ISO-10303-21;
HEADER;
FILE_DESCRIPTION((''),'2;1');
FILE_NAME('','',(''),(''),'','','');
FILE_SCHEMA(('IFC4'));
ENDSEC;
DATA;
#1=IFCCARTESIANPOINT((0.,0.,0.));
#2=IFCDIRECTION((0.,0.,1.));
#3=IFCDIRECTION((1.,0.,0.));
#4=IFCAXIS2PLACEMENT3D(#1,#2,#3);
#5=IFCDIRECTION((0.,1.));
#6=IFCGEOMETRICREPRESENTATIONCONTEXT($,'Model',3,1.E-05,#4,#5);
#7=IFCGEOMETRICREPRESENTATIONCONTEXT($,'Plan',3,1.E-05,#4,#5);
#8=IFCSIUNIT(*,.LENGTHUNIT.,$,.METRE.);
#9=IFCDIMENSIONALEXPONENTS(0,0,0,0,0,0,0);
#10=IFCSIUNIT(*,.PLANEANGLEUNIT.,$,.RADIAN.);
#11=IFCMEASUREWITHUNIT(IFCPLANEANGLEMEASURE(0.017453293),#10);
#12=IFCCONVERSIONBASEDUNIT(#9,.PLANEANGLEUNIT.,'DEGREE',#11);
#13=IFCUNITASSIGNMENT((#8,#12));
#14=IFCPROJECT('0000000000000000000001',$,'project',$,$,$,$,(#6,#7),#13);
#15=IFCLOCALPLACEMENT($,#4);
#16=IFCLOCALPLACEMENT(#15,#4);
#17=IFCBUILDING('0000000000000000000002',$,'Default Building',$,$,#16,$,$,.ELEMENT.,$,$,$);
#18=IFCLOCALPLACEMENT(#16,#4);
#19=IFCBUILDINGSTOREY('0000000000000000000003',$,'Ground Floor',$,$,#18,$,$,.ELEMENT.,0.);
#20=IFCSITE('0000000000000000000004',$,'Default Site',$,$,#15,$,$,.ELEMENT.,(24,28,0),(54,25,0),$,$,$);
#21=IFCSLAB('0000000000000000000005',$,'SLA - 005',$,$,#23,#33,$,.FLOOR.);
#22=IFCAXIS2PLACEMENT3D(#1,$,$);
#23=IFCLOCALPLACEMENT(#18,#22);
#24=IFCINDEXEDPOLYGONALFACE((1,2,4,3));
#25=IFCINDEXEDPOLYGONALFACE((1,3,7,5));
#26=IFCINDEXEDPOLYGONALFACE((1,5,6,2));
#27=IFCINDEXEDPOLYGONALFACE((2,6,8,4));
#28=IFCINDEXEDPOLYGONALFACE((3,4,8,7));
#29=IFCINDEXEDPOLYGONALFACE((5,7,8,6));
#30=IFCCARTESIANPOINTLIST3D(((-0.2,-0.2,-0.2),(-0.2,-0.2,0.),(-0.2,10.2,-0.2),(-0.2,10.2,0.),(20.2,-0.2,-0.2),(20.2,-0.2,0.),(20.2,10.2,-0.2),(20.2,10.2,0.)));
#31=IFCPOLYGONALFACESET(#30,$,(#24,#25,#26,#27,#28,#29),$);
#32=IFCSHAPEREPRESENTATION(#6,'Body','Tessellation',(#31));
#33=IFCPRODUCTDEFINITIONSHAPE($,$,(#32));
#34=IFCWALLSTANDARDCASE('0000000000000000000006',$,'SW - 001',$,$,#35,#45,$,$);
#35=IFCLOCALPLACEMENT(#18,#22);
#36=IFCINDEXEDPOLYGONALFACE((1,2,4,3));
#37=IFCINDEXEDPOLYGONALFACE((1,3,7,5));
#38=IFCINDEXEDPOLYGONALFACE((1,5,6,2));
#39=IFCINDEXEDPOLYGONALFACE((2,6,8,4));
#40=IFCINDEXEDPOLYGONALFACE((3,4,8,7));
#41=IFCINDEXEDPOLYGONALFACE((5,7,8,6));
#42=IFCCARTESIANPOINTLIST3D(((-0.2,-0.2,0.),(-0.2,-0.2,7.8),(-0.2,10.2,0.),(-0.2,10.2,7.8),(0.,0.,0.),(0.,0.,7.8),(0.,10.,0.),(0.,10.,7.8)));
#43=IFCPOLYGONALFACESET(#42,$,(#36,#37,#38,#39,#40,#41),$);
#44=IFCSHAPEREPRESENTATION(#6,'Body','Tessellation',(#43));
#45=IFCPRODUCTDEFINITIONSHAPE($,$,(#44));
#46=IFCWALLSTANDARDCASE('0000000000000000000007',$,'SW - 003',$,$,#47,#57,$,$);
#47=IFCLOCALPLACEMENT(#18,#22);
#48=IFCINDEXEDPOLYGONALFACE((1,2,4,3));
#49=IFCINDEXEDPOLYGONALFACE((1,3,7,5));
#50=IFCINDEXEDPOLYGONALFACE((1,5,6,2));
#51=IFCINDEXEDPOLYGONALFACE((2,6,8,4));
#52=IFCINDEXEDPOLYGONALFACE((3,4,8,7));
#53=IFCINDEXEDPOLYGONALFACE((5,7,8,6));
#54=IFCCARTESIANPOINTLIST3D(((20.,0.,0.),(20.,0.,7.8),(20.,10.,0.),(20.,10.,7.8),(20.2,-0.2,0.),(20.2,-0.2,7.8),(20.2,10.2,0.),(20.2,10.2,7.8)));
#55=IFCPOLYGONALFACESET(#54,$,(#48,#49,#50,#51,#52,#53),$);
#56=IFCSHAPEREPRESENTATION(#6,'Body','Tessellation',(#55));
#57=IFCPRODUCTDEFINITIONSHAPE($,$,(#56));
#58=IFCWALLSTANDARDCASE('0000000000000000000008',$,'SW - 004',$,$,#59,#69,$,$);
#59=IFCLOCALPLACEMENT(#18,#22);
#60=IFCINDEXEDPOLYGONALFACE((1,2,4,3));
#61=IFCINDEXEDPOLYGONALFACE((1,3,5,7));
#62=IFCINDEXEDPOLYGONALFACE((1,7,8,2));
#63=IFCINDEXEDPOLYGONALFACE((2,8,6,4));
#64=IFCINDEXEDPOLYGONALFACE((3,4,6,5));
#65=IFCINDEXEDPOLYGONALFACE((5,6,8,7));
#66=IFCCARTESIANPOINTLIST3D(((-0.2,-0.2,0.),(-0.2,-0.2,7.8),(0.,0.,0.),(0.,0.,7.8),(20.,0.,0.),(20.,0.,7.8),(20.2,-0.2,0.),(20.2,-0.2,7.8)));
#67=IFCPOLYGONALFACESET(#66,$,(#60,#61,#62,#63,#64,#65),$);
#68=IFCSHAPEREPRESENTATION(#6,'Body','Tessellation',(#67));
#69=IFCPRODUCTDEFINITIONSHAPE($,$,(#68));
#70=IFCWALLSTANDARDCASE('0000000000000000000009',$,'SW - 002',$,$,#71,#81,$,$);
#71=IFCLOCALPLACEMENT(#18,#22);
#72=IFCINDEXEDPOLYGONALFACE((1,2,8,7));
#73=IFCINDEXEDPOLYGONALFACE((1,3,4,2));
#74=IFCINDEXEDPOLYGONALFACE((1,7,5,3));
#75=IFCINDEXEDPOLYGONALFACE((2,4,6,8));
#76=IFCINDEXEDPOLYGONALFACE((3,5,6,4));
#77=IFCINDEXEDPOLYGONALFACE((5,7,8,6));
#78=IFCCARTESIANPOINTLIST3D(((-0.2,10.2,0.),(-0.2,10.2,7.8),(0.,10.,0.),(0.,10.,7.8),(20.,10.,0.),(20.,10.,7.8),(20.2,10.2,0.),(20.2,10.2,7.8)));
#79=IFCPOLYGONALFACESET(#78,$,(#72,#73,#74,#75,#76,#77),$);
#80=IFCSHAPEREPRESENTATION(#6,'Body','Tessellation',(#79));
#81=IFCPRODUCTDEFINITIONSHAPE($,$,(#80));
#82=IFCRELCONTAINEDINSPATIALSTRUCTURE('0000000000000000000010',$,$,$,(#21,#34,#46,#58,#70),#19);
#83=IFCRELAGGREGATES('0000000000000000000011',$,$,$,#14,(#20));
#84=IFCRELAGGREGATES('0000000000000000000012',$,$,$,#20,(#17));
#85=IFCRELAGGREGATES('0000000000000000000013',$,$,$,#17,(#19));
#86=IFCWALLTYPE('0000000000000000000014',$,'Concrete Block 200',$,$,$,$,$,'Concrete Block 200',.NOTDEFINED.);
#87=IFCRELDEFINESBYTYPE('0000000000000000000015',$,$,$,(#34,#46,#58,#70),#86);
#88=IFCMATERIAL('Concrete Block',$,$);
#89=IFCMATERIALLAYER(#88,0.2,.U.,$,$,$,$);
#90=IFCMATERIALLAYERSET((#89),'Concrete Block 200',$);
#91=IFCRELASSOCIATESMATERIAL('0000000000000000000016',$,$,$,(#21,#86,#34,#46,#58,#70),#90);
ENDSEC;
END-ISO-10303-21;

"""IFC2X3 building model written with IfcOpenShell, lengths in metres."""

from ifc_helpers import new_model, entity, si_unit, converted_unit, direction, frame, origin_with_axes, place, context, project, spatial, polyline, outline, extrude, material, layer, layer_set, layer_usage, type_object, element, save


model = new_model("IFC2X3")

# Units and contexts
model_context = context("Model", 3, precision=1e-05, world=origin_with_axes(), true_north=direction((0.0, 1.0)))
plan_context = context("Plan", 3, precision=1e-05, world=origin_with_axes(), true_north=direction((0.0, 1.0)))
ifc_project = project(units=[si_unit("LENGTHUNIT", "METRE"), converted_unit("PLANEANGLEUNIT", "DEGREE", entity("IfcPlaneAngleMeasure", 0.017453293), si_unit("PLANEANGLEUNIT", "RADIAN"), dimensions=[0, 0, 0, 0, 0, 0, 0])], contexts=[model_context, plan_context])

# Site, building, storey
site_placement = place(None, origin_with_axes())
site = spatial("IfcSite", under=ifc_project, at=site_placement, Name="Default Site", CompositionType="ELEMENT", RefLatitude=(24, 28, 0), RefLongitude=(54, 25, 0))
building_placement = place(site_placement, origin_with_axes())
building = spatial("IfcBuilding", under=site, at=building_placement, Name="Default Building", CompositionType="ELEMENT")
storey_placement = place(building_placement, origin_with_axes())
storey = spatial("IfcBuildingStorey", under=building, at=storey_placement, Name="Ground Floor", CompositionType="ELEMENT", Elevation=0.0)

# Slab
ifc_material = material(Name="Concrete Block")
ifc_layer = layer(ifc_material, 0.2, ventilated="UNKNOWN")
ifc_layer_set = layer_set([ifc_layer], Name="Concrete Block 200")
ifc_layer_usage_1 = layer_usage(ifc_layer_set, "AXIS3", "NEGATIVE", 0.2)
slab_placement = place(storey_placement, frame((-0.2, 10.2, -0.2), z_axis=(0.0, 0.0, 1.0), x_axis=(1.0, 0.0, 0.0)))
element("IfcSlab", 1, at=slab_placement, inside=storey, material=ifc_layer_usage_1, Name="SLA - 005", PredefinedType="FLOOR", context=model_context, shape_type="SweptSolid", body=[
    extrude(outline(polyline([(0.0, 0.0), (20.4, 0.0), (20.4, -10.4), (0.0, -10.4), (0.0, 0.0)])), origin_with_axes(), (0.0, 0.0, 1.0), 0.2),
])

# Walls
ifc_layer_usage_2 = layer_usage(ifc_layer_set, "AXIS2", "POSITIVE", 0.0)
wall_type = type_object("IfcWallType", Name="Concrete Block 200", ElementType="Concrete Block 200", PredefinedType="NOTDEFINED", material=ifc_layer_set)
wall_1_placement = place(storey_placement, frame((0.0, 0.0, 0.0), z_axis=(0.0, 0.0, 1.0), x_axis=(0.0, 1.0, 0.0)))
element("IfcWallStandardCase", 2, at=wall_1_placement, inside=storey, type_object=wall_type, material=ifc_layer_usage_2, Name="SW - 001", context=model_context, shape_type="SweptSolid", body=[
    extrude(outline(polyline([(0.0, 0.0), (10.0, 0.0), (10.2, 0.2), (-0.2, 0.2), (0.0, 0.0)])), origin_with_axes(), (0.0, 0.0, 1.0), 7.8),
])
ifc_layer_usage_3 = layer_usage(ifc_layer_set, "AXIS2", "POSITIVE", 0.0)
wall_2_placement = place(storey_placement, frame((20.0, 10.0, 0.0), z_axis=(0.0, 0.0, 1.0), x_axis=(0.0, -1.0, 0.0)))
element("IfcWallStandardCase", 3, at=wall_2_placement, inside=storey, type_object=wall_type, material=ifc_layer_usage_3, Name="SW - 003", context=model_context, shape_type="SweptSolid", body=[
    extrude(outline(polyline([(0.0, 0.0), (10.0, 0.0), (10.2, 0.2), (-0.2, 0.2), (0.0, 0.0)])), origin_with_axes(), (0.0, 0.0, 1.0), 7.8),
])
ifc_layer_usage_4 = layer_usage(ifc_layer_set, "AXIS2", "POSITIVE", 0.0)
wall_3_placement = place(storey_placement, frame((20.0, 0.0, 0.0), z_axis=(0.0, 0.0, 1.0), x_axis=(-1.0, 0.0, 0.0)))
element("IfcWallStandardCase", 4, at=wall_3_placement, inside=storey, type_object=wall_type, material=ifc_layer_usage_4, Name="SW - 004", context=model_context, shape_type="SweptSolid", body=[
    extrude(outline(polyline([(0.0, 0.0), (20.0, 0.0), (20.2, 0.2), (-0.2, 0.2), (0.0, 0.0)])), origin_with_axes(), (0.0, 0.0, 1.0), 7.8),
])
ifc_layer_usage_5 = layer_usage(ifc_layer_set, "AXIS2", "POSITIVE", 0.0)
wall_4_placement = place(storey_placement, frame((0.0, 10.0, 0.0), z_axis=(0.0, 0.0, 1.0), x_axis=(1.0, 0.0, 0.0)))
element("IfcWallStandardCase", 5, at=wall_4_placement, inside=storey, type_object=wall_type, material=ifc_layer_usage_5, Name="SW - 002", context=model_context, shape_type="SweptSolid", body=[
    extrude(outline(polyline([(0.0, 0.0), (20.0, 0.0), (20.2, 0.2), (-0.2, 0.2), (0.0, 0.0)])), origin_with_axes(), (0.0, 0.0, 1.0), 7.8),
])

save(model, "model.ifc")
